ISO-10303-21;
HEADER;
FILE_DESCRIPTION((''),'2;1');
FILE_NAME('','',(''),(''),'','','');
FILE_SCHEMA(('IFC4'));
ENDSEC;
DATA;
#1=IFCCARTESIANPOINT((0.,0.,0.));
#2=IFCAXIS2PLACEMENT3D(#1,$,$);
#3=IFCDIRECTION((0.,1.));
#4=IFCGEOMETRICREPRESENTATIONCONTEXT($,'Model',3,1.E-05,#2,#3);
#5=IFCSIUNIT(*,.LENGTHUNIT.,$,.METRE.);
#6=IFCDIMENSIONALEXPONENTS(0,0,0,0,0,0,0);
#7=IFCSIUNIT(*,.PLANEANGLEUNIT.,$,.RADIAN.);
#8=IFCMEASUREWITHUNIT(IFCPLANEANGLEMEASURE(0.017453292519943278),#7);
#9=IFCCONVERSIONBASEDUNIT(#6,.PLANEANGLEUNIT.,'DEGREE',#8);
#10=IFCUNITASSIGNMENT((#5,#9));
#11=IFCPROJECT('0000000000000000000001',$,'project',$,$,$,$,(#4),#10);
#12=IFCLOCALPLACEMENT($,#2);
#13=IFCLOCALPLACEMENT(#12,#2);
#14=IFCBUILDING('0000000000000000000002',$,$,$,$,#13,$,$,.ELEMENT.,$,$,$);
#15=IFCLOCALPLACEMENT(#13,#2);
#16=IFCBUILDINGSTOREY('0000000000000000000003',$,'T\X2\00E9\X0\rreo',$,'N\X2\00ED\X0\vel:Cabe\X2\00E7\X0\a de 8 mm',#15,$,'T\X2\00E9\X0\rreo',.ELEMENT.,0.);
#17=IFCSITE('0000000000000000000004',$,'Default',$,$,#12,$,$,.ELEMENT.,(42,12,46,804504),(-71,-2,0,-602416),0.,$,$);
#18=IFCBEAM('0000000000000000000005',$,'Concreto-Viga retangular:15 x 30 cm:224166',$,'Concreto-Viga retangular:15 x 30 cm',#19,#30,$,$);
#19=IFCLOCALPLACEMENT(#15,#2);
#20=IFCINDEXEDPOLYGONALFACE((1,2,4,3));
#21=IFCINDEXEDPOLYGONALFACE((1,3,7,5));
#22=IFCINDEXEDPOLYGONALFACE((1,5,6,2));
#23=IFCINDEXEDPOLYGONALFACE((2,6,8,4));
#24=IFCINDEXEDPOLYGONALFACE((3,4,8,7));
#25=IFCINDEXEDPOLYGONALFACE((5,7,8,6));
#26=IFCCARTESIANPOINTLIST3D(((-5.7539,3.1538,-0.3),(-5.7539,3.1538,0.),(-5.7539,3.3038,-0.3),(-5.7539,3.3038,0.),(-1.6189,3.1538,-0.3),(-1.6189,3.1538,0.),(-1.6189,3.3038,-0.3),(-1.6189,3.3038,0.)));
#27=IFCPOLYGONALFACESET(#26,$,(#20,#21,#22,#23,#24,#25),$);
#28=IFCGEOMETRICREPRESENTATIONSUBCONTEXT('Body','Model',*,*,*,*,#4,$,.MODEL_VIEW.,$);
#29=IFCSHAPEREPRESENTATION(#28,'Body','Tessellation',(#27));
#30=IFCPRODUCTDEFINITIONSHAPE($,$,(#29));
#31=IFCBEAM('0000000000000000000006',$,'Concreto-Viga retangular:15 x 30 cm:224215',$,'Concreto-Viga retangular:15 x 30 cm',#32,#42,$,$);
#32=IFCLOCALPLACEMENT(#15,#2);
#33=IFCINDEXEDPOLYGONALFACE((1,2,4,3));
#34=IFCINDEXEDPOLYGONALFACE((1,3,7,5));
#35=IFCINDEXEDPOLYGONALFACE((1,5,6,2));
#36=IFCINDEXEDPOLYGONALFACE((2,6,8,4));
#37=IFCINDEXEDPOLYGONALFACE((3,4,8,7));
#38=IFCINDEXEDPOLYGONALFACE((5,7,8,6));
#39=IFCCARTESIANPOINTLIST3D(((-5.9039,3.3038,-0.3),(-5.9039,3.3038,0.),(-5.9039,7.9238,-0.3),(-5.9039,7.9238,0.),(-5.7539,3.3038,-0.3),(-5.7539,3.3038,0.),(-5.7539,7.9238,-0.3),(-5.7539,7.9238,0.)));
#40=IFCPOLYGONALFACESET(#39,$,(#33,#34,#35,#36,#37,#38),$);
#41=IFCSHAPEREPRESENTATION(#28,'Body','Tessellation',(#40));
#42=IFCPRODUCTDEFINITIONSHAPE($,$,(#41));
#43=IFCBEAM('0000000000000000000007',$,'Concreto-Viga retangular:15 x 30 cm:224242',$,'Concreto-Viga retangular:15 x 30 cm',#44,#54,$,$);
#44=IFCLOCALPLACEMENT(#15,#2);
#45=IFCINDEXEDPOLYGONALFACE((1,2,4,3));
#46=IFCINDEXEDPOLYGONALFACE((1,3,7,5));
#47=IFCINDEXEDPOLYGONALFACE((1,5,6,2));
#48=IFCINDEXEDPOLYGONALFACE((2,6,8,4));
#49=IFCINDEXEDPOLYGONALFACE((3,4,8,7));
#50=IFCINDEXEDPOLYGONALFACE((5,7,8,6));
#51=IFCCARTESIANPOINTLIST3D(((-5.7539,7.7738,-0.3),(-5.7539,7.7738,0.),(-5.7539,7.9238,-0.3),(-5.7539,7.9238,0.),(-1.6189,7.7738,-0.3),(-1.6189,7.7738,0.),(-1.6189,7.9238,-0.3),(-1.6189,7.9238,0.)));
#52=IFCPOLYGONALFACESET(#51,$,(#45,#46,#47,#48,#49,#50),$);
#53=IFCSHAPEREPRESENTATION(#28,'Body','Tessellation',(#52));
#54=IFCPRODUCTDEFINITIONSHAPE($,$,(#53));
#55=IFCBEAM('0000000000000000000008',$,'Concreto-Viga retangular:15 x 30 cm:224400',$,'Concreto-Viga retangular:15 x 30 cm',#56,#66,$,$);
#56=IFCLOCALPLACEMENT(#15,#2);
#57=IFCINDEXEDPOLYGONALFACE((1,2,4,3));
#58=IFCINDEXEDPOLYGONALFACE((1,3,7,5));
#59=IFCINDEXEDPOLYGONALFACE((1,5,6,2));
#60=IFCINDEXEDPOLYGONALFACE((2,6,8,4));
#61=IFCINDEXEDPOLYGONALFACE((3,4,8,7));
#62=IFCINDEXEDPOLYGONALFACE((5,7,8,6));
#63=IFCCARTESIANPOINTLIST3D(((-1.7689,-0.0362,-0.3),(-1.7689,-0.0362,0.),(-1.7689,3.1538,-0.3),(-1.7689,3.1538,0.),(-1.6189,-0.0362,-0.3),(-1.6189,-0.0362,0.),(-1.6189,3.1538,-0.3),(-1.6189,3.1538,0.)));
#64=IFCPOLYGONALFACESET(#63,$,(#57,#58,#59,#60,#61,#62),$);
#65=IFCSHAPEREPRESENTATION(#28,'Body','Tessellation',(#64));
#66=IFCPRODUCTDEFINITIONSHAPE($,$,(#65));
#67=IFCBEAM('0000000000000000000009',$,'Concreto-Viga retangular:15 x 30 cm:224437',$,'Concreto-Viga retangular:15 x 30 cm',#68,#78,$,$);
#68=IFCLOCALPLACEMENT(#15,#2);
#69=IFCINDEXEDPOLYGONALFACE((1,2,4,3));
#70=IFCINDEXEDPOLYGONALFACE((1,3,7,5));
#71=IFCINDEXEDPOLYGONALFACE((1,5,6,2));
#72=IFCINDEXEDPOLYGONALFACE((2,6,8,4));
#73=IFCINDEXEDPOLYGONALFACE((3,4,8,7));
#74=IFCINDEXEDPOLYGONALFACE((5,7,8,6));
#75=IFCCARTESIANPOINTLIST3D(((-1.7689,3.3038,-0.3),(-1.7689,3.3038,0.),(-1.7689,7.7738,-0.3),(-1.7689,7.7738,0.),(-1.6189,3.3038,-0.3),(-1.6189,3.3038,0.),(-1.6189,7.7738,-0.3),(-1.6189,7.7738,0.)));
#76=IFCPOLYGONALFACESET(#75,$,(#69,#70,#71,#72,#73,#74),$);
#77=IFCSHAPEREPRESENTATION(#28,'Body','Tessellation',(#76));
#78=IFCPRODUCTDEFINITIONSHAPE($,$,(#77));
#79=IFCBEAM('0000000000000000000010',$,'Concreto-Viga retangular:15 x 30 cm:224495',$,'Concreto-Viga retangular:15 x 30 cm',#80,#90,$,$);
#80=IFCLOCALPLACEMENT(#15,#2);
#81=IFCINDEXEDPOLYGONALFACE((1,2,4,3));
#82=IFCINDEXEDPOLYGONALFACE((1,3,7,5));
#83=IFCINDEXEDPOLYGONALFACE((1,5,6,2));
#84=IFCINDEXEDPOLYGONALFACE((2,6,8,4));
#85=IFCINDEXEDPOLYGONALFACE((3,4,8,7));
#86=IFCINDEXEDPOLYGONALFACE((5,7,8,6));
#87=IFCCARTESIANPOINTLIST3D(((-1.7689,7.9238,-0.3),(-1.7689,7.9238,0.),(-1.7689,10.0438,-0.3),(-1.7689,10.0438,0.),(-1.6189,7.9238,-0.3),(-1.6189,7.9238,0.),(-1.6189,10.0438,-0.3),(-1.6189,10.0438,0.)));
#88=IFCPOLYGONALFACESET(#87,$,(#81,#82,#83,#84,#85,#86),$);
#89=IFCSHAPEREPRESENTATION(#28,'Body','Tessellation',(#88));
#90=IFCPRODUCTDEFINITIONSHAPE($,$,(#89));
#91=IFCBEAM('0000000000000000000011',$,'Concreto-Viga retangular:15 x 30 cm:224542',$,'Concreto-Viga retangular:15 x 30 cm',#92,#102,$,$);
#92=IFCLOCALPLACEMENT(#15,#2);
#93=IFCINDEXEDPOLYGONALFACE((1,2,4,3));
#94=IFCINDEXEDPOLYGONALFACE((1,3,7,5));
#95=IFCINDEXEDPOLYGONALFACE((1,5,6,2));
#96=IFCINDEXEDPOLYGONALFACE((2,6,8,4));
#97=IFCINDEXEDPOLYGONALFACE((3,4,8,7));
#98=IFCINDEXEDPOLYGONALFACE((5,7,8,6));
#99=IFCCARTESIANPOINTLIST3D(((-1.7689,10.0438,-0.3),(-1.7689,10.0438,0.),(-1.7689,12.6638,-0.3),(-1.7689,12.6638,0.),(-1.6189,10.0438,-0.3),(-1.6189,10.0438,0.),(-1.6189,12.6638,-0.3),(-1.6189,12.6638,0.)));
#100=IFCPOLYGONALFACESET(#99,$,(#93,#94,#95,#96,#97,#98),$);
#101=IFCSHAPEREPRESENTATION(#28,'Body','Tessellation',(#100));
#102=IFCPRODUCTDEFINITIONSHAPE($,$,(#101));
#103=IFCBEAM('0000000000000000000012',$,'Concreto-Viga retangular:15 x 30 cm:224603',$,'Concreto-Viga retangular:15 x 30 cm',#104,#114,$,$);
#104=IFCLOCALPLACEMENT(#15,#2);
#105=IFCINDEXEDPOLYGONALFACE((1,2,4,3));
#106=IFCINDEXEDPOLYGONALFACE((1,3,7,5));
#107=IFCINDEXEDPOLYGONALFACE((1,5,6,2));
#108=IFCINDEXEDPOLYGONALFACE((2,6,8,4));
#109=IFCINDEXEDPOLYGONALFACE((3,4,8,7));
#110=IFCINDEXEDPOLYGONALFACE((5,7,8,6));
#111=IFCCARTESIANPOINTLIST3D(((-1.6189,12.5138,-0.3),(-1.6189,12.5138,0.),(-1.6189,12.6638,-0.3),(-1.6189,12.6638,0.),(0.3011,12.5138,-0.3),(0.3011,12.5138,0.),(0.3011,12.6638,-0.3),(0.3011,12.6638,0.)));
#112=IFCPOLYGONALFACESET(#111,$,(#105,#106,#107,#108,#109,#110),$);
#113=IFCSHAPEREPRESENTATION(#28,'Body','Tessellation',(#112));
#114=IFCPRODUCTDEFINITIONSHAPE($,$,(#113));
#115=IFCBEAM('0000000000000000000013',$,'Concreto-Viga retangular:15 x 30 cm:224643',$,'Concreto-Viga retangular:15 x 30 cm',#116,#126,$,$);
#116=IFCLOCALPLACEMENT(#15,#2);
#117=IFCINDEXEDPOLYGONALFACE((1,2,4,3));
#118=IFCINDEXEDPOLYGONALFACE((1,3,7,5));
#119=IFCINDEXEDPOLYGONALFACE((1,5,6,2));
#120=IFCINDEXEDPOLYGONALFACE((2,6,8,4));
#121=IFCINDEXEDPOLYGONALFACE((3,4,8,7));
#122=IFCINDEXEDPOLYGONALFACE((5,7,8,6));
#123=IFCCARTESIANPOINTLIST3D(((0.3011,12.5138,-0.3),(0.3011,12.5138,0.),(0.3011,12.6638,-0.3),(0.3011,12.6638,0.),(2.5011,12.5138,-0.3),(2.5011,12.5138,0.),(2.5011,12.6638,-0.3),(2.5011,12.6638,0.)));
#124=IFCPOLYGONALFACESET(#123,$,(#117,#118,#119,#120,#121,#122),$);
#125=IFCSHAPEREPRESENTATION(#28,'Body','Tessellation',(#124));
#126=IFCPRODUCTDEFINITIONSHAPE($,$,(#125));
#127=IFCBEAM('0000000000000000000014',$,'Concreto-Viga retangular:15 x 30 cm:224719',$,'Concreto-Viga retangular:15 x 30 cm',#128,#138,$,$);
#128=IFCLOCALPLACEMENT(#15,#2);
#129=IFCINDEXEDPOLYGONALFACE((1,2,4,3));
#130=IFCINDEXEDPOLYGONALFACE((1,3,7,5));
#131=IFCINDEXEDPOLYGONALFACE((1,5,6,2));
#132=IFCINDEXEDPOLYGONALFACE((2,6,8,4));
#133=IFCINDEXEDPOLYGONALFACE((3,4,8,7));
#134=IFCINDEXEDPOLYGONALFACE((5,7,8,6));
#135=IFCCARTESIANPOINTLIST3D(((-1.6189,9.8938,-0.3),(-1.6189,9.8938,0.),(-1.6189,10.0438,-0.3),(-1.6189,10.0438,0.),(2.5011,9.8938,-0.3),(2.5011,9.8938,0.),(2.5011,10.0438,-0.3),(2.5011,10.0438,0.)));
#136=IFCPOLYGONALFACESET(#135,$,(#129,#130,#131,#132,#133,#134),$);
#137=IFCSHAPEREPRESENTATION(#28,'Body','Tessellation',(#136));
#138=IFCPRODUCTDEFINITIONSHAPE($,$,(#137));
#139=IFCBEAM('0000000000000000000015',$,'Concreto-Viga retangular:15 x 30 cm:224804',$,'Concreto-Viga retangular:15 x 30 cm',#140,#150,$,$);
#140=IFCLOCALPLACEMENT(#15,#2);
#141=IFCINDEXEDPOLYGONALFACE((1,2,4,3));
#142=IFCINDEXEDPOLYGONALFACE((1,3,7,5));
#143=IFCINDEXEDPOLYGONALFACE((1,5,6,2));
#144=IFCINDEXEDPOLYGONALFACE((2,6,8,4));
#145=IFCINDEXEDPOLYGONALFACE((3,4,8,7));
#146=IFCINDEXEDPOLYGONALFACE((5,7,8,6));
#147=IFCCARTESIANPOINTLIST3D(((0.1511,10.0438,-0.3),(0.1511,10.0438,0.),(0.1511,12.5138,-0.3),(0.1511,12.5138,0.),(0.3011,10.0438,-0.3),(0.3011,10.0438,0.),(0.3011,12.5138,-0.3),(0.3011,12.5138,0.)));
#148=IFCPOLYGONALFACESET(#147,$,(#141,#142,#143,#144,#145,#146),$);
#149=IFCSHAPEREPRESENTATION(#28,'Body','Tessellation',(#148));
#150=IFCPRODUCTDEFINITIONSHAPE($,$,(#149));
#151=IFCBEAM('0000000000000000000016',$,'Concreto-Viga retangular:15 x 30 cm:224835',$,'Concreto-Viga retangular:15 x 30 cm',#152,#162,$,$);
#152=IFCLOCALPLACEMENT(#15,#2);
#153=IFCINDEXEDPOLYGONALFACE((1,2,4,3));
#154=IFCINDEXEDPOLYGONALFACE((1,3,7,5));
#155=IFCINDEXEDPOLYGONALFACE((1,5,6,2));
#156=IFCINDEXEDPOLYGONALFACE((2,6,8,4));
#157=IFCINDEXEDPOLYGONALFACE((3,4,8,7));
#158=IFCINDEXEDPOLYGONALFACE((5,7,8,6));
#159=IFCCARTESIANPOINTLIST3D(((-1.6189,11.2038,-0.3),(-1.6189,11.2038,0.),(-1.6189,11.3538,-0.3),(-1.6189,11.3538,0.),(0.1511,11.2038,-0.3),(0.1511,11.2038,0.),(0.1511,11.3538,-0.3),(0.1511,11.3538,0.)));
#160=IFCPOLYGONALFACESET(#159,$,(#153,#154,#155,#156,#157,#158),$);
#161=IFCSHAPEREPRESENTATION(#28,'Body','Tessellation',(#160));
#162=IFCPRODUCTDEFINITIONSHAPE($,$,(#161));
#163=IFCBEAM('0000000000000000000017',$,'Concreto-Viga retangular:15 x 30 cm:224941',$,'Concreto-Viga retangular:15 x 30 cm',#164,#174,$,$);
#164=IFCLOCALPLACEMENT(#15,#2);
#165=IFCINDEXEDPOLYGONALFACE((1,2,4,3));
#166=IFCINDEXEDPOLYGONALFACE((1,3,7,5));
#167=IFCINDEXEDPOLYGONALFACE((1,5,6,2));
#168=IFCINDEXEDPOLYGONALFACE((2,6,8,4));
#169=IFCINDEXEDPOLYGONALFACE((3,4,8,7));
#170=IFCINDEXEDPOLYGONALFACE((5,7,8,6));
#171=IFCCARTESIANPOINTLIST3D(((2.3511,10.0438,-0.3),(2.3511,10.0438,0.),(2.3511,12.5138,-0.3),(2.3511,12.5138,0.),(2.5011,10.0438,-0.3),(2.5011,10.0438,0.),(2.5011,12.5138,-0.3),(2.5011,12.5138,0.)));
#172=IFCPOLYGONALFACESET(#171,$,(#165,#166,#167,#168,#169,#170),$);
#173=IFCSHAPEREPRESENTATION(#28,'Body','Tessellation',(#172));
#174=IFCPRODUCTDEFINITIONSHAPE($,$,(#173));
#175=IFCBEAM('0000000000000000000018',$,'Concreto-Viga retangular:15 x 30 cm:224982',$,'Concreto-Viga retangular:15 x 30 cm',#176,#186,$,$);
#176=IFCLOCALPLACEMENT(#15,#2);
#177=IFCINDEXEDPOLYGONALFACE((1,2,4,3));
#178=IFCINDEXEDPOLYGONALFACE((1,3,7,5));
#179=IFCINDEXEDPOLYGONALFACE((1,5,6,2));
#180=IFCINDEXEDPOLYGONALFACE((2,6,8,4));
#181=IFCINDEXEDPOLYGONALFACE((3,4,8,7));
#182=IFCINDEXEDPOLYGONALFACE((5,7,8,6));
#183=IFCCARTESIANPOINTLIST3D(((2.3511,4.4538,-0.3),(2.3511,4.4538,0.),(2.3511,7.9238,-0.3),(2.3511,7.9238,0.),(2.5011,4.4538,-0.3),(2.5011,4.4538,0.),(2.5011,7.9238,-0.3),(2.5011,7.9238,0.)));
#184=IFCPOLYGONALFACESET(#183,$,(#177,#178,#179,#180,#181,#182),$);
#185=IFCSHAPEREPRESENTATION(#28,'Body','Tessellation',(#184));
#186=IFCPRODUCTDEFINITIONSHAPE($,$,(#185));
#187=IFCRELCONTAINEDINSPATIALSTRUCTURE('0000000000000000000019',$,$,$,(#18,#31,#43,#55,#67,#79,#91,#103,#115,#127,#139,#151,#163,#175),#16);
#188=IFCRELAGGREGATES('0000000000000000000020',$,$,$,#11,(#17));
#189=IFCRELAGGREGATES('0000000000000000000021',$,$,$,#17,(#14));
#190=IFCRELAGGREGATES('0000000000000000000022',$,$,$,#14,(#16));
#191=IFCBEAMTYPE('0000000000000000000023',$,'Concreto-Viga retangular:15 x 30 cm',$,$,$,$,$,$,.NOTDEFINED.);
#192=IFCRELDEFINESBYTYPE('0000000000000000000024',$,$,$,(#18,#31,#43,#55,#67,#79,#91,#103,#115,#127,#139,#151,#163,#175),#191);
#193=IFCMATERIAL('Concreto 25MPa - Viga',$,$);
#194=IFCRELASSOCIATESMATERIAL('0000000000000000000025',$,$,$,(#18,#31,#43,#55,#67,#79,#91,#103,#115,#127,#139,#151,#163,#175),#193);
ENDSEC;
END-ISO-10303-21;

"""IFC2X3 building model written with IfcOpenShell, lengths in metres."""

from ifc_helpers import new_model, entity, si_unit, converted_unit, direction, frame, frame_2d, origin, place, context, subcontext, project, spatial, rectangle, extrude, material, type_object, element, save


model = new_model("IFC2X3")

# Units and contexts
model_context = context("Model", 3, precision=1e-05, world=origin(), true_north=direction((0.0, 1.0)))
body_context = subcontext(model_context, "Body", "Model", "MODEL_VIEW")
ifc_project = project(units=[si_unit("LENGTHUNIT", "METRE"), converted_unit("PLANEANGLEUNIT", "DEGREE", entity("IfcPlaneAngleMeasure", 0.017453292519943278), si_unit("PLANEANGLEUNIT", "RADIAN"), dimensions=[0, 0, 0, 0, 0, 0, 0])], contexts=[model_context])

# Site, building, storey
site_placement = place(None, origin())
site = spatial("IfcSite", under=ifc_project, at=site_placement, Name="Default", CompositionType="ELEMENT", RefLatitude=(42, 12, 46, 804504), RefLongitude=(-71, -2, 0, -602416), RefElevation=0.0)
building_placement = place(site_placement, origin())
building = spatial("IfcBuilding", under=site, at=building_placement, CompositionType="ELEMENT")
storey_placement = place(building_placement, origin())
storey = spatial("IfcBuildingStorey", under=building, at=storey_placement, Name="Térreo", ObjectType="Nível:Cabeça de 8 mm", LongName="Térreo", CompositionType="ELEMENT", Elevation=0.0)

# Beams
ifc_material_1 = material(Name="Concreto 25MPa - Viga")
beam_type = type_object("IfcBeamType", Name="Concreto-Viga retangular:15 x 30 cm", PredefinedType="NOTDEFINED")
beam_1_placement = place(storey_placement, frame((-5.8289, 3.2288, 0.0)))
element("IfcBeam", 1, at=beam_1_placement, inside=storey, type_object=beam_type, material=ifc_material_1, Name="Concreto-Viga retangular:15 x 30 cm:224166", ObjectType="Concreto-Viga retangular:15 x 30 cm", context=body_context, shape_type="SweptSolid", body=[
    extrude(rectangle(XDim=0.3, YDim=0.15, at=frame_2d((0.0, 0.0), x_axis=(1.0, 0.0))), frame((0.075, 0.0, -0.15), z_axis=(1.0, 0.0, 0.0), x_axis=(0.0, 0.0, -1.0)), (0.0, 0.0, 1.0), 4.135),
])
beam_2_placement = place(storey_placement, frame((-5.8289, 3.2288, 0.0), z_axis=(0.0, 0.0, 1.0), x_axis=(0.0, 1.0, 0.0)))
element("IfcBeam", 2, at=beam_2_placement, inside=storey, type_object=beam_type, material=ifc_material_1, Name="Concreto-Viga retangular:15 x 30 cm:224215", ObjectType="Concreto-Viga retangular:15 x 30 cm", context=body_context, shape_type="SweptSolid", body=[
    extrude(rectangle(XDim=0.3, YDim=0.15, at=frame_2d((0.0, 0.0), x_axis=(1.0, 0.0))), frame((0.075, 0.0, -0.15), z_axis=(1.0, 0.0, 0.0), x_axis=(0.0, 0.0, -1.0)), (0.0, 0.0, 1.0), 4.62),
])
beam_3_placement = place(storey_placement, frame((-5.8289, 7.8488, 0.0)))
element("IfcBeam", 3, at=beam_3_placement, inside=storey, type_object=beam_type, material=ifc_material_1, Name="Concreto-Viga retangular:15 x 30 cm:224242", ObjectType="Concreto-Viga retangular:15 x 30 cm", context=body_context, shape_type="SweptSolid", body=[
    extrude(rectangle(XDim=0.3, YDim=0.15, at=frame_2d((0.0, 0.0), x_axis=(1.0, 0.0))), frame((0.075, 0.0, -0.15), z_axis=(1.0, 0.0, 0.0), x_axis=(0.0, 0.0, -1.0)), (0.0, 0.0, 1.0), 4.135),
])
beam_4_placement = place(storey_placement, frame((-1.6939, 3.2288, 0.0), z_axis=(0.0, 0.0, 1.0), x_axis=(0.0, -1.0, 0.0)))
element("IfcBeam", 4, at=beam_4_placement, inside=storey, type_object=beam_type, material=ifc_material_1, Name="Concreto-Viga retangular:15 x 30 cm:224400", ObjectType="Concreto-Viga retangular:15 x 30 cm", context=body_context, shape_type="SweptSolid", body=[
    extrude(rectangle(XDim=0.3, YDim=0.15, at=frame_2d((0.0, 0.0), x_axis=(1.0, 0.0))), frame((0.075, 0.0, -0.15), z_axis=(1.0, 0.0, 0.0), x_axis=(0.0, 0.0, -1.0)), (0.0, 0.0, 1.0), 3.19),
])
beam_5_placement = place(storey_placement, frame((-1.6939, 3.2288, 0.0), z_axis=(0.0, 0.0, 1.0), x_axis=(0.0, 1.0, 0.0)))
element("IfcBeam", 5, at=beam_5_placement, inside=storey, type_object=beam_type, material=ifc_material_1, Name="Concreto-Viga retangular:15 x 30 cm:224437", ObjectType="Concreto-Viga retangular:15 x 30 cm", context=body_context, shape_type="SweptSolid", body=[
    extrude(rectangle(XDim=0.3, YDim=0.15, at=frame_2d((0.0, 0.0), x_axis=(1.0, 0.0))), frame((0.075, 0.0, -0.15), z_axis=(1.0, 0.0, 0.0), x_axis=(0.0, 0.0, -1.0)), (0.0, 0.0, 1.0), 4.47),
])
beam_6_placement = place(storey_placement, frame((-1.6939, 9.9688, 0.0), z_axis=(0.0, 0.0, 1.0), x_axis=(0.0, -1.0, 0.0)))
element("IfcBeam", 6, at=beam_6_placement, inside=storey, type_object=beam_type, material=ifc_material_1, Name="Concreto-Viga retangular:15 x 30 cm:224495", ObjectType="Concreto-Viga retangular:15 x 30 cm", context=body_context, shape_type="SweptSolid", body=[
    extrude(rectangle(XDim=0.3, YDim=0.15, at=frame_2d((0.0, 0.0), x_axis=(1.0, 0.0))), frame((-0.075, 0.0, -0.15), z_axis=(1.0, 0.0, 0.0), x_axis=(0.0, 0.0, -1.0)), (0.0, 0.0, 1.0), 2.12),
])
beam_7_placement = place(storey_placement, frame((-1.6939, 12.5888, 0.0), z_axis=(0.0, 0.0, 1.0), x_axis=(0.0, -1.0, 0.0)))
element("IfcBeam", 7, at=beam_7_placement, inside=storey, type_object=beam_type, material=ifc_material_1, Name="Concreto-Viga retangular:15 x 30 cm:224542", ObjectType="Concreto-Viga retangular:15 x 30 cm", context=body_context, shape_type="SweptSolid", body=[
    extrude(rectangle(XDim=0.3, YDim=0.15, at=frame_2d((0.0, 0.0), x_axis=(1.0, 0.0))), frame((-0.075, 0.0, -0.15), z_axis=(1.0, 0.0, 0.0), x_axis=(0.0, 0.0, -1.0)), (0.0, 0.0, 1.0), 2.62),
])
beam_8_placement = place(storey_placement, frame((-1.6939, 12.5888, 0.0)))
element("IfcBeam", 8, at=beam_8_placement, inside=storey, type_object=beam_type, material=ifc_material_1, Name="Concreto-Viga retangular:15 x 30 cm:224603", ObjectType="Concreto-Viga retangular:15 x 30 cm", context=body_context, shape_type="SweptSolid", body=[
    extrude(rectangle(XDim=0.3, YDim=0.15, at=frame_2d((0.0, 0.0), x_axis=(1.0, 0.0))), frame((0.075, 0.0, -0.15), z_axis=(1.0, 0.0, 0.0), x_axis=(0.0, 0.0, -1.0)), (0.0, 0.0, 1.0), 1.92),
])
beam_9_placement = place(storey_placement, frame((0.2261, 12.5888, 0.0)))
element("IfcBeam", 9, at=beam_9_placement, inside=storey, type_object=beam_type, material=ifc_material_1, Name="Concreto-Viga retangular:15 x 30 cm:224643", ObjectType="Concreto-Viga retangular:15 x 30 cm", context=body_context, shape_type="SweptSolid", body=[
    extrude(rectangle(XDim=0.3, YDim=0.15, at=frame_2d((0.0, 0.0), x_axis=(1.0, 0.0))), frame((0.075, 0.0, -0.15), z_axis=(1.0, 0.0, 0.0), x_axis=(0.0, 0.0, -1.0)), (0.0, 0.0, 1.0), 2.2),
])
beam_10_placement = place(storey_placement, frame((-1.6939, 9.9688, 0.0)))
element("IfcBeam", 10, at=beam_10_placement, inside=storey, type_object=beam_type, material=ifc_material_1, Name="Concreto-Viga retangular:15 x 30 cm:224719", ObjectType="Concreto-Viga retangular:15 x 30 cm", context=body_context, shape_type="SweptSolid", body=[
    extrude(rectangle(XDim=0.3, YDim=0.15, at=frame_2d((0.0, 0.0), x_axis=(1.0, 0.0))), frame((0.075, 0.0, -0.15), z_axis=(1.0, 0.0, 0.0), x_axis=(0.0, 0.0, -1.0)), (0.0, 0.0, 1.0), 4.12),
])
beam_11_placement = place(storey_placement, frame((0.2261, 12.5888, 0.0), z_axis=(0.0, 0.0, 1.0), x_axis=(0.0, -1.0, 0.0)))
element("IfcBeam", 11, at=beam_11_placement, inside=storey, type_object=beam_type, material=ifc_material_1, Name="Concreto-Viga retangular:15 x 30 cm:224804", ObjectType="Concreto-Viga retangular:15 x 30 cm", context=body_context, shape_type="SweptSolid", body=[
    extrude(rectangle(XDim=0.3, YDim=0.15, at=frame_2d((0.0, 0.0), x_axis=(1.0, 0.0))), frame((0.075, 0.0, -0.15), z_axis=(1.0, 0.0, 0.0), x_axis=(0.0, 0.0, -1.0)), (0.0, 0.0, 1.0), 2.47),
])
beam_12_placement = place(storey_placement, frame((-1.6939, 11.2788, 0.0)))
element("IfcBeam", 12, at=beam_12_placement, inside=storey, type_object=beam_type, material=ifc_material_1, Name="Concreto-Viga retangular:15 x 30 cm:224835", ObjectType="Concreto-Viga retangular:15 x 30 cm", context=body_context, shape_type="SweptSolid", body=[
    extrude(rectangle(XDim=0.3, YDim=0.15, at=frame_2d((0.0, 0.0), x_axis=(1.0, 0.0))), frame((0.075, 0.0, -0.15), z_axis=(1.0, 0.0, 0.0), x_axis=(0.0, 0.0, -1.0)), (0.0, 0.0, 1.0), 1.77),
])
beam_13_placement = place(storey_placement, frame((2.4261, 12.5888, 0.0), z_axis=(0.0, 0.0, 1.0), x_axis=(0.0, -1.0, 0.0)))
element("IfcBeam", 13, at=beam_13_placement, inside=storey, type_object=beam_type, material=ifc_material_1, Name="Concreto-Viga retangular:15 x 30 cm:224941", ObjectType="Concreto-Viga retangular:15 x 30 cm", context=body_context, shape_type="SweptSolid", body=[
    extrude(rectangle(XDim=0.3, YDim=0.15, at=frame_2d((0.0, 0.0), x_axis=(1.0, 0.0))), frame((0.075, 0.0, -0.15), z_axis=(1.0, 0.0, 0.0), x_axis=(0.0, 0.0, -1.0)), (0.0, 0.0, 1.0), 2.47),
])
beam_14_placement = place(storey_placement, frame((2.4261, 7.8488, 0.0), z_axis=(0.0, 0.0, 1.0), x_axis=(0.0, -1.0, 0.0)))
element("IfcBeam", 14, at=beam_14_placement, inside=storey, type_object=beam_type, material=ifc_material_1, Name="Concreto-Viga retangular:15 x 30 cm:224982", ObjectType="Concreto-Viga retangular:15 x 30 cm", context=body_context, shape_type="SweptSolid", body=[
    extrude(rectangle(XDim=0.3, YDim=0.15, at=frame_2d((0.0, 0.0), x_axis=(1.0, 0.0))), frame((-0.075, 0.0, -0.15), z_axis=(1.0, 0.0, 0.0), x_axis=(0.0, 0.0, -1.0)), (0.0, 0.0, 1.0), 3.47),
])

save(model, "model.ifc")
